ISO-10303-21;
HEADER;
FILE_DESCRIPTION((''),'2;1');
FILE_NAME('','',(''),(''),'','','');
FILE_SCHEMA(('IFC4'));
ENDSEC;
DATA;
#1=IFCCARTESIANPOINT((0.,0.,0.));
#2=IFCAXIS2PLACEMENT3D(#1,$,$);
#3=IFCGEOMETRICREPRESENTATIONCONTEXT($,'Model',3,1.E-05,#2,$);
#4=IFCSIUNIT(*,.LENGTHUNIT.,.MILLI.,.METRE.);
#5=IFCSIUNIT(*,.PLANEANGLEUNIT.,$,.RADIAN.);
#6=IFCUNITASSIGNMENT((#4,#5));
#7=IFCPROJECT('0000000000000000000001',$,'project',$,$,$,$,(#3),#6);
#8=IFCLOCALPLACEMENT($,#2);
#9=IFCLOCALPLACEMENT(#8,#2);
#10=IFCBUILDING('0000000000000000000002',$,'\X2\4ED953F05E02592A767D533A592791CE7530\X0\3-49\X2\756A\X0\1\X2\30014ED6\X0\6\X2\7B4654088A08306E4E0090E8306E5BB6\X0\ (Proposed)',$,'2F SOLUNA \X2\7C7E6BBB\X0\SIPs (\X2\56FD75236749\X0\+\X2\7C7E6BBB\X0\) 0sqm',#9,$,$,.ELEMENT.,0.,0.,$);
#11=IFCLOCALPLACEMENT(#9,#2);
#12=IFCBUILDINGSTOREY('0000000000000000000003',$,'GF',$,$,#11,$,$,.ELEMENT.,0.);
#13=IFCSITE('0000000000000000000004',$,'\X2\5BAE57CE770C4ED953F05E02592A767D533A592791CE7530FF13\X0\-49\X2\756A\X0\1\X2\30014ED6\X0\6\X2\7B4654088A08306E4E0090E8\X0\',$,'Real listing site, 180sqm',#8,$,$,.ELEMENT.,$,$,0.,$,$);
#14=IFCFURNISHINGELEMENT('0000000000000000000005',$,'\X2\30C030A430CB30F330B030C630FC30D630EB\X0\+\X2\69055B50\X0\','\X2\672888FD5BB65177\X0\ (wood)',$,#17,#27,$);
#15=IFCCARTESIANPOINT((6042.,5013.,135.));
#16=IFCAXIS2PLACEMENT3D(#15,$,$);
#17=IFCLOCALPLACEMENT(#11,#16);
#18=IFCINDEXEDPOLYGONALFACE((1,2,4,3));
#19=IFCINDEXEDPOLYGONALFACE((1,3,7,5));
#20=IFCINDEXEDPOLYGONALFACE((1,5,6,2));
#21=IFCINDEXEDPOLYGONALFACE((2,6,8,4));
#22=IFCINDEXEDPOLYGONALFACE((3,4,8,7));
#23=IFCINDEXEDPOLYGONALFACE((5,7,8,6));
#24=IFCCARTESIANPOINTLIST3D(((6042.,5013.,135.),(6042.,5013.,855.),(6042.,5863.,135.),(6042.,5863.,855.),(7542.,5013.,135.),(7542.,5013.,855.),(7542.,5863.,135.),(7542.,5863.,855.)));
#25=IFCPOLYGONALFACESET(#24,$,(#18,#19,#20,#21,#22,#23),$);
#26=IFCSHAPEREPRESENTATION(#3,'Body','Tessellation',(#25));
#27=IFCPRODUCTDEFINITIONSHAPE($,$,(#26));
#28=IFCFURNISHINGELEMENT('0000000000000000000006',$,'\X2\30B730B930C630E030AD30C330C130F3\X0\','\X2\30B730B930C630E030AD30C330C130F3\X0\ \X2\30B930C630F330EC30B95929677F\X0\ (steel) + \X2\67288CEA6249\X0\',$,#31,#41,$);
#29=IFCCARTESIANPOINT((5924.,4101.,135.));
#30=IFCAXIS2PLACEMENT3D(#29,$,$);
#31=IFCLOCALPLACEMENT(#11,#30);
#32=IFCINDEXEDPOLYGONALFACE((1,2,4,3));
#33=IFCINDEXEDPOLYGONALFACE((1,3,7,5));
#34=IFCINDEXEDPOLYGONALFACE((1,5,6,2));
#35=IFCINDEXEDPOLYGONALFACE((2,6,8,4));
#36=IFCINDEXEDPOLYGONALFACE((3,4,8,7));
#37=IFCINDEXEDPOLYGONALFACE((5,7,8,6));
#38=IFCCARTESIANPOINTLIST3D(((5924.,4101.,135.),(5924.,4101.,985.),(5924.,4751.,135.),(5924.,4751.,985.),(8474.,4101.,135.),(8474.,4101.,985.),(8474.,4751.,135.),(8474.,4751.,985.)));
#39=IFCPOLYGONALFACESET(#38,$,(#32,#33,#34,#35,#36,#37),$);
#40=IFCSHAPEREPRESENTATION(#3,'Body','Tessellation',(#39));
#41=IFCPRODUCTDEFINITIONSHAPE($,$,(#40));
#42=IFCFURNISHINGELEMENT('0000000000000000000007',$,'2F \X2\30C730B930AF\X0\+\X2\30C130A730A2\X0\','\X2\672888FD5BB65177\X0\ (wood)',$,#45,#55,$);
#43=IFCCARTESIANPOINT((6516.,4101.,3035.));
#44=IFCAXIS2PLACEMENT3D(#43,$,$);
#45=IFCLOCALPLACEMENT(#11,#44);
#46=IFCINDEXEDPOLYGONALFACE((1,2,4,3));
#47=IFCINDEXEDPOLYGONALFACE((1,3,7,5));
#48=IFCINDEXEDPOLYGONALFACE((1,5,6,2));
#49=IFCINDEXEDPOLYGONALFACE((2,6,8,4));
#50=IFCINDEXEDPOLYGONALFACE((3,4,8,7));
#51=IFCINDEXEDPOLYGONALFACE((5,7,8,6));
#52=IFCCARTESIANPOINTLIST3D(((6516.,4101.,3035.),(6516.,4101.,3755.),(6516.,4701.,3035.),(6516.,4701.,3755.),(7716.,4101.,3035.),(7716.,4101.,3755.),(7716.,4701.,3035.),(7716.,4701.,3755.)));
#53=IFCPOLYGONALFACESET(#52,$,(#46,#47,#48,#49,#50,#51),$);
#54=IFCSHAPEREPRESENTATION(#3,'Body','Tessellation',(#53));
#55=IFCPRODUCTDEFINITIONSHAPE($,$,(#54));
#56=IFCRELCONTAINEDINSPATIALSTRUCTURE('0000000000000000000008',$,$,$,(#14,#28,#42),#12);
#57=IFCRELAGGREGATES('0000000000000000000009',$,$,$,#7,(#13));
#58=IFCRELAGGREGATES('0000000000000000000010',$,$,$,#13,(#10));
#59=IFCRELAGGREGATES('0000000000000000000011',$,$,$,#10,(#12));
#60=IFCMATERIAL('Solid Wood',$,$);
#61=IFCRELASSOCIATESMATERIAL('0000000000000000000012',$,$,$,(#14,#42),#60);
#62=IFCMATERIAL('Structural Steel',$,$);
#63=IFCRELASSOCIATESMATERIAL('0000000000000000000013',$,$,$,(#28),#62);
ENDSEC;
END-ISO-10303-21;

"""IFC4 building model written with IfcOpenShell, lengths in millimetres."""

from ifc_helpers import new_model, si_unit, frame, frame_2d, origin, place, context, project, spatial, rectangle, extrude, material, element, save


model = new_model("IFC4")

# Units and contexts
model_context = context("Model", 3, precision=1e-05, world=origin())
ifc_project = project(units=[si_unit("LENGTHUNIT", "METRE", prefix="MILLI"), si_unit("PLANEANGLEUNIT", "RADIAN")], contexts=[model_context])

# Site, building, storey
site_placement = place(None, origin())
site = spatial("IfcSite", under=ifc_project, at=site_placement, Name="宮城県仙台市太白区大野田３-49番1、他6筆合計の一部", ObjectType="Real listing site, 180sqm", CompositionType="ELEMENT", RefElevation=0.0)
building_placement = place(site_placement, origin())
building = spatial("IfcBuilding", under=site, at=building_placement, Name="仙台市太白区大野田3-49番1、他6筆合計の一部の家 (Proposed)", ObjectType="2F SOLUNA 籾殻SIPs (国産杉+籾殻) 0sqm", CompositionType="ELEMENT", ElevationOfRefHeight=0.0, ElevationOfTerrain=0.0)
storey_placement = place(building_placement, origin())
storey = spatial("IfcBuildingStorey", under=building, at=storey_placement, Name="GF", CompositionType="ELEMENT", Elevation=0.0)

# Shared definitions
ifc_material_1 = material(Name="Solid Wood")

# Shared definitions
ifc_material_2 = material(Name="Structural Steel")

# Furnishing elements
furnishing_1_placement = place(storey_placement, frame((6042.0, 5013.0, 135.0)))
element("IfcFurnishingElement", 1, at=furnishing_1_placement, inside=storey, material=ifc_material_1, Name="ダイニングテーブル+椅子", Description="木製家具 (wood)", context=model_context, shape_type="SweptSolid", body=[
    extrude(rectangle(XDim=1500.0, YDim=850.0, at=frame_2d((750.0, 425.0))), frame((6042.0, 5013.0, 135.0)), (0.0, 0.0, 1.0), 720.0),
])
furnishing_2_placement = place(storey_placement, frame((5924.0, 4101.0, 135.0)))
element("IfcFurnishingElement", 2, at=furnishing_2_placement, inside=storey, material=ifc_material_2, Name="システムキッチン", Description="システムキッチン ステンレス天板 (steel) + 木質扉", context=model_context, shape_type="SweptSolid", body=[
    extrude(rectangle(XDim=2550.0, YDim=650.0, at=frame_2d((1275.0, 325.0))), frame((5924.0, 4101.0, 135.0)), (0.0, 0.0, 1.0), 850.0),
])
furnishing_3_placement = place(storey_placement, frame((6516.0, 4101.0, 3035.0)))
element("IfcFurnishingElement", 3, at=furnishing_3_placement, inside=storey, material=ifc_material_1, Name="2F デスク+チェア", Description="木製家具 (wood)", context=model_context, shape_type="SweptSolid", body=[
    extrude(rectangle(XDim=1200.0, YDim=600.0, at=frame_2d((600.0, 300.0))), frame((6516.0, 4101.0, 3035.0)), (0.0, 0.0, 1.0), 720.0),
])

save(model, "model.ifc")
